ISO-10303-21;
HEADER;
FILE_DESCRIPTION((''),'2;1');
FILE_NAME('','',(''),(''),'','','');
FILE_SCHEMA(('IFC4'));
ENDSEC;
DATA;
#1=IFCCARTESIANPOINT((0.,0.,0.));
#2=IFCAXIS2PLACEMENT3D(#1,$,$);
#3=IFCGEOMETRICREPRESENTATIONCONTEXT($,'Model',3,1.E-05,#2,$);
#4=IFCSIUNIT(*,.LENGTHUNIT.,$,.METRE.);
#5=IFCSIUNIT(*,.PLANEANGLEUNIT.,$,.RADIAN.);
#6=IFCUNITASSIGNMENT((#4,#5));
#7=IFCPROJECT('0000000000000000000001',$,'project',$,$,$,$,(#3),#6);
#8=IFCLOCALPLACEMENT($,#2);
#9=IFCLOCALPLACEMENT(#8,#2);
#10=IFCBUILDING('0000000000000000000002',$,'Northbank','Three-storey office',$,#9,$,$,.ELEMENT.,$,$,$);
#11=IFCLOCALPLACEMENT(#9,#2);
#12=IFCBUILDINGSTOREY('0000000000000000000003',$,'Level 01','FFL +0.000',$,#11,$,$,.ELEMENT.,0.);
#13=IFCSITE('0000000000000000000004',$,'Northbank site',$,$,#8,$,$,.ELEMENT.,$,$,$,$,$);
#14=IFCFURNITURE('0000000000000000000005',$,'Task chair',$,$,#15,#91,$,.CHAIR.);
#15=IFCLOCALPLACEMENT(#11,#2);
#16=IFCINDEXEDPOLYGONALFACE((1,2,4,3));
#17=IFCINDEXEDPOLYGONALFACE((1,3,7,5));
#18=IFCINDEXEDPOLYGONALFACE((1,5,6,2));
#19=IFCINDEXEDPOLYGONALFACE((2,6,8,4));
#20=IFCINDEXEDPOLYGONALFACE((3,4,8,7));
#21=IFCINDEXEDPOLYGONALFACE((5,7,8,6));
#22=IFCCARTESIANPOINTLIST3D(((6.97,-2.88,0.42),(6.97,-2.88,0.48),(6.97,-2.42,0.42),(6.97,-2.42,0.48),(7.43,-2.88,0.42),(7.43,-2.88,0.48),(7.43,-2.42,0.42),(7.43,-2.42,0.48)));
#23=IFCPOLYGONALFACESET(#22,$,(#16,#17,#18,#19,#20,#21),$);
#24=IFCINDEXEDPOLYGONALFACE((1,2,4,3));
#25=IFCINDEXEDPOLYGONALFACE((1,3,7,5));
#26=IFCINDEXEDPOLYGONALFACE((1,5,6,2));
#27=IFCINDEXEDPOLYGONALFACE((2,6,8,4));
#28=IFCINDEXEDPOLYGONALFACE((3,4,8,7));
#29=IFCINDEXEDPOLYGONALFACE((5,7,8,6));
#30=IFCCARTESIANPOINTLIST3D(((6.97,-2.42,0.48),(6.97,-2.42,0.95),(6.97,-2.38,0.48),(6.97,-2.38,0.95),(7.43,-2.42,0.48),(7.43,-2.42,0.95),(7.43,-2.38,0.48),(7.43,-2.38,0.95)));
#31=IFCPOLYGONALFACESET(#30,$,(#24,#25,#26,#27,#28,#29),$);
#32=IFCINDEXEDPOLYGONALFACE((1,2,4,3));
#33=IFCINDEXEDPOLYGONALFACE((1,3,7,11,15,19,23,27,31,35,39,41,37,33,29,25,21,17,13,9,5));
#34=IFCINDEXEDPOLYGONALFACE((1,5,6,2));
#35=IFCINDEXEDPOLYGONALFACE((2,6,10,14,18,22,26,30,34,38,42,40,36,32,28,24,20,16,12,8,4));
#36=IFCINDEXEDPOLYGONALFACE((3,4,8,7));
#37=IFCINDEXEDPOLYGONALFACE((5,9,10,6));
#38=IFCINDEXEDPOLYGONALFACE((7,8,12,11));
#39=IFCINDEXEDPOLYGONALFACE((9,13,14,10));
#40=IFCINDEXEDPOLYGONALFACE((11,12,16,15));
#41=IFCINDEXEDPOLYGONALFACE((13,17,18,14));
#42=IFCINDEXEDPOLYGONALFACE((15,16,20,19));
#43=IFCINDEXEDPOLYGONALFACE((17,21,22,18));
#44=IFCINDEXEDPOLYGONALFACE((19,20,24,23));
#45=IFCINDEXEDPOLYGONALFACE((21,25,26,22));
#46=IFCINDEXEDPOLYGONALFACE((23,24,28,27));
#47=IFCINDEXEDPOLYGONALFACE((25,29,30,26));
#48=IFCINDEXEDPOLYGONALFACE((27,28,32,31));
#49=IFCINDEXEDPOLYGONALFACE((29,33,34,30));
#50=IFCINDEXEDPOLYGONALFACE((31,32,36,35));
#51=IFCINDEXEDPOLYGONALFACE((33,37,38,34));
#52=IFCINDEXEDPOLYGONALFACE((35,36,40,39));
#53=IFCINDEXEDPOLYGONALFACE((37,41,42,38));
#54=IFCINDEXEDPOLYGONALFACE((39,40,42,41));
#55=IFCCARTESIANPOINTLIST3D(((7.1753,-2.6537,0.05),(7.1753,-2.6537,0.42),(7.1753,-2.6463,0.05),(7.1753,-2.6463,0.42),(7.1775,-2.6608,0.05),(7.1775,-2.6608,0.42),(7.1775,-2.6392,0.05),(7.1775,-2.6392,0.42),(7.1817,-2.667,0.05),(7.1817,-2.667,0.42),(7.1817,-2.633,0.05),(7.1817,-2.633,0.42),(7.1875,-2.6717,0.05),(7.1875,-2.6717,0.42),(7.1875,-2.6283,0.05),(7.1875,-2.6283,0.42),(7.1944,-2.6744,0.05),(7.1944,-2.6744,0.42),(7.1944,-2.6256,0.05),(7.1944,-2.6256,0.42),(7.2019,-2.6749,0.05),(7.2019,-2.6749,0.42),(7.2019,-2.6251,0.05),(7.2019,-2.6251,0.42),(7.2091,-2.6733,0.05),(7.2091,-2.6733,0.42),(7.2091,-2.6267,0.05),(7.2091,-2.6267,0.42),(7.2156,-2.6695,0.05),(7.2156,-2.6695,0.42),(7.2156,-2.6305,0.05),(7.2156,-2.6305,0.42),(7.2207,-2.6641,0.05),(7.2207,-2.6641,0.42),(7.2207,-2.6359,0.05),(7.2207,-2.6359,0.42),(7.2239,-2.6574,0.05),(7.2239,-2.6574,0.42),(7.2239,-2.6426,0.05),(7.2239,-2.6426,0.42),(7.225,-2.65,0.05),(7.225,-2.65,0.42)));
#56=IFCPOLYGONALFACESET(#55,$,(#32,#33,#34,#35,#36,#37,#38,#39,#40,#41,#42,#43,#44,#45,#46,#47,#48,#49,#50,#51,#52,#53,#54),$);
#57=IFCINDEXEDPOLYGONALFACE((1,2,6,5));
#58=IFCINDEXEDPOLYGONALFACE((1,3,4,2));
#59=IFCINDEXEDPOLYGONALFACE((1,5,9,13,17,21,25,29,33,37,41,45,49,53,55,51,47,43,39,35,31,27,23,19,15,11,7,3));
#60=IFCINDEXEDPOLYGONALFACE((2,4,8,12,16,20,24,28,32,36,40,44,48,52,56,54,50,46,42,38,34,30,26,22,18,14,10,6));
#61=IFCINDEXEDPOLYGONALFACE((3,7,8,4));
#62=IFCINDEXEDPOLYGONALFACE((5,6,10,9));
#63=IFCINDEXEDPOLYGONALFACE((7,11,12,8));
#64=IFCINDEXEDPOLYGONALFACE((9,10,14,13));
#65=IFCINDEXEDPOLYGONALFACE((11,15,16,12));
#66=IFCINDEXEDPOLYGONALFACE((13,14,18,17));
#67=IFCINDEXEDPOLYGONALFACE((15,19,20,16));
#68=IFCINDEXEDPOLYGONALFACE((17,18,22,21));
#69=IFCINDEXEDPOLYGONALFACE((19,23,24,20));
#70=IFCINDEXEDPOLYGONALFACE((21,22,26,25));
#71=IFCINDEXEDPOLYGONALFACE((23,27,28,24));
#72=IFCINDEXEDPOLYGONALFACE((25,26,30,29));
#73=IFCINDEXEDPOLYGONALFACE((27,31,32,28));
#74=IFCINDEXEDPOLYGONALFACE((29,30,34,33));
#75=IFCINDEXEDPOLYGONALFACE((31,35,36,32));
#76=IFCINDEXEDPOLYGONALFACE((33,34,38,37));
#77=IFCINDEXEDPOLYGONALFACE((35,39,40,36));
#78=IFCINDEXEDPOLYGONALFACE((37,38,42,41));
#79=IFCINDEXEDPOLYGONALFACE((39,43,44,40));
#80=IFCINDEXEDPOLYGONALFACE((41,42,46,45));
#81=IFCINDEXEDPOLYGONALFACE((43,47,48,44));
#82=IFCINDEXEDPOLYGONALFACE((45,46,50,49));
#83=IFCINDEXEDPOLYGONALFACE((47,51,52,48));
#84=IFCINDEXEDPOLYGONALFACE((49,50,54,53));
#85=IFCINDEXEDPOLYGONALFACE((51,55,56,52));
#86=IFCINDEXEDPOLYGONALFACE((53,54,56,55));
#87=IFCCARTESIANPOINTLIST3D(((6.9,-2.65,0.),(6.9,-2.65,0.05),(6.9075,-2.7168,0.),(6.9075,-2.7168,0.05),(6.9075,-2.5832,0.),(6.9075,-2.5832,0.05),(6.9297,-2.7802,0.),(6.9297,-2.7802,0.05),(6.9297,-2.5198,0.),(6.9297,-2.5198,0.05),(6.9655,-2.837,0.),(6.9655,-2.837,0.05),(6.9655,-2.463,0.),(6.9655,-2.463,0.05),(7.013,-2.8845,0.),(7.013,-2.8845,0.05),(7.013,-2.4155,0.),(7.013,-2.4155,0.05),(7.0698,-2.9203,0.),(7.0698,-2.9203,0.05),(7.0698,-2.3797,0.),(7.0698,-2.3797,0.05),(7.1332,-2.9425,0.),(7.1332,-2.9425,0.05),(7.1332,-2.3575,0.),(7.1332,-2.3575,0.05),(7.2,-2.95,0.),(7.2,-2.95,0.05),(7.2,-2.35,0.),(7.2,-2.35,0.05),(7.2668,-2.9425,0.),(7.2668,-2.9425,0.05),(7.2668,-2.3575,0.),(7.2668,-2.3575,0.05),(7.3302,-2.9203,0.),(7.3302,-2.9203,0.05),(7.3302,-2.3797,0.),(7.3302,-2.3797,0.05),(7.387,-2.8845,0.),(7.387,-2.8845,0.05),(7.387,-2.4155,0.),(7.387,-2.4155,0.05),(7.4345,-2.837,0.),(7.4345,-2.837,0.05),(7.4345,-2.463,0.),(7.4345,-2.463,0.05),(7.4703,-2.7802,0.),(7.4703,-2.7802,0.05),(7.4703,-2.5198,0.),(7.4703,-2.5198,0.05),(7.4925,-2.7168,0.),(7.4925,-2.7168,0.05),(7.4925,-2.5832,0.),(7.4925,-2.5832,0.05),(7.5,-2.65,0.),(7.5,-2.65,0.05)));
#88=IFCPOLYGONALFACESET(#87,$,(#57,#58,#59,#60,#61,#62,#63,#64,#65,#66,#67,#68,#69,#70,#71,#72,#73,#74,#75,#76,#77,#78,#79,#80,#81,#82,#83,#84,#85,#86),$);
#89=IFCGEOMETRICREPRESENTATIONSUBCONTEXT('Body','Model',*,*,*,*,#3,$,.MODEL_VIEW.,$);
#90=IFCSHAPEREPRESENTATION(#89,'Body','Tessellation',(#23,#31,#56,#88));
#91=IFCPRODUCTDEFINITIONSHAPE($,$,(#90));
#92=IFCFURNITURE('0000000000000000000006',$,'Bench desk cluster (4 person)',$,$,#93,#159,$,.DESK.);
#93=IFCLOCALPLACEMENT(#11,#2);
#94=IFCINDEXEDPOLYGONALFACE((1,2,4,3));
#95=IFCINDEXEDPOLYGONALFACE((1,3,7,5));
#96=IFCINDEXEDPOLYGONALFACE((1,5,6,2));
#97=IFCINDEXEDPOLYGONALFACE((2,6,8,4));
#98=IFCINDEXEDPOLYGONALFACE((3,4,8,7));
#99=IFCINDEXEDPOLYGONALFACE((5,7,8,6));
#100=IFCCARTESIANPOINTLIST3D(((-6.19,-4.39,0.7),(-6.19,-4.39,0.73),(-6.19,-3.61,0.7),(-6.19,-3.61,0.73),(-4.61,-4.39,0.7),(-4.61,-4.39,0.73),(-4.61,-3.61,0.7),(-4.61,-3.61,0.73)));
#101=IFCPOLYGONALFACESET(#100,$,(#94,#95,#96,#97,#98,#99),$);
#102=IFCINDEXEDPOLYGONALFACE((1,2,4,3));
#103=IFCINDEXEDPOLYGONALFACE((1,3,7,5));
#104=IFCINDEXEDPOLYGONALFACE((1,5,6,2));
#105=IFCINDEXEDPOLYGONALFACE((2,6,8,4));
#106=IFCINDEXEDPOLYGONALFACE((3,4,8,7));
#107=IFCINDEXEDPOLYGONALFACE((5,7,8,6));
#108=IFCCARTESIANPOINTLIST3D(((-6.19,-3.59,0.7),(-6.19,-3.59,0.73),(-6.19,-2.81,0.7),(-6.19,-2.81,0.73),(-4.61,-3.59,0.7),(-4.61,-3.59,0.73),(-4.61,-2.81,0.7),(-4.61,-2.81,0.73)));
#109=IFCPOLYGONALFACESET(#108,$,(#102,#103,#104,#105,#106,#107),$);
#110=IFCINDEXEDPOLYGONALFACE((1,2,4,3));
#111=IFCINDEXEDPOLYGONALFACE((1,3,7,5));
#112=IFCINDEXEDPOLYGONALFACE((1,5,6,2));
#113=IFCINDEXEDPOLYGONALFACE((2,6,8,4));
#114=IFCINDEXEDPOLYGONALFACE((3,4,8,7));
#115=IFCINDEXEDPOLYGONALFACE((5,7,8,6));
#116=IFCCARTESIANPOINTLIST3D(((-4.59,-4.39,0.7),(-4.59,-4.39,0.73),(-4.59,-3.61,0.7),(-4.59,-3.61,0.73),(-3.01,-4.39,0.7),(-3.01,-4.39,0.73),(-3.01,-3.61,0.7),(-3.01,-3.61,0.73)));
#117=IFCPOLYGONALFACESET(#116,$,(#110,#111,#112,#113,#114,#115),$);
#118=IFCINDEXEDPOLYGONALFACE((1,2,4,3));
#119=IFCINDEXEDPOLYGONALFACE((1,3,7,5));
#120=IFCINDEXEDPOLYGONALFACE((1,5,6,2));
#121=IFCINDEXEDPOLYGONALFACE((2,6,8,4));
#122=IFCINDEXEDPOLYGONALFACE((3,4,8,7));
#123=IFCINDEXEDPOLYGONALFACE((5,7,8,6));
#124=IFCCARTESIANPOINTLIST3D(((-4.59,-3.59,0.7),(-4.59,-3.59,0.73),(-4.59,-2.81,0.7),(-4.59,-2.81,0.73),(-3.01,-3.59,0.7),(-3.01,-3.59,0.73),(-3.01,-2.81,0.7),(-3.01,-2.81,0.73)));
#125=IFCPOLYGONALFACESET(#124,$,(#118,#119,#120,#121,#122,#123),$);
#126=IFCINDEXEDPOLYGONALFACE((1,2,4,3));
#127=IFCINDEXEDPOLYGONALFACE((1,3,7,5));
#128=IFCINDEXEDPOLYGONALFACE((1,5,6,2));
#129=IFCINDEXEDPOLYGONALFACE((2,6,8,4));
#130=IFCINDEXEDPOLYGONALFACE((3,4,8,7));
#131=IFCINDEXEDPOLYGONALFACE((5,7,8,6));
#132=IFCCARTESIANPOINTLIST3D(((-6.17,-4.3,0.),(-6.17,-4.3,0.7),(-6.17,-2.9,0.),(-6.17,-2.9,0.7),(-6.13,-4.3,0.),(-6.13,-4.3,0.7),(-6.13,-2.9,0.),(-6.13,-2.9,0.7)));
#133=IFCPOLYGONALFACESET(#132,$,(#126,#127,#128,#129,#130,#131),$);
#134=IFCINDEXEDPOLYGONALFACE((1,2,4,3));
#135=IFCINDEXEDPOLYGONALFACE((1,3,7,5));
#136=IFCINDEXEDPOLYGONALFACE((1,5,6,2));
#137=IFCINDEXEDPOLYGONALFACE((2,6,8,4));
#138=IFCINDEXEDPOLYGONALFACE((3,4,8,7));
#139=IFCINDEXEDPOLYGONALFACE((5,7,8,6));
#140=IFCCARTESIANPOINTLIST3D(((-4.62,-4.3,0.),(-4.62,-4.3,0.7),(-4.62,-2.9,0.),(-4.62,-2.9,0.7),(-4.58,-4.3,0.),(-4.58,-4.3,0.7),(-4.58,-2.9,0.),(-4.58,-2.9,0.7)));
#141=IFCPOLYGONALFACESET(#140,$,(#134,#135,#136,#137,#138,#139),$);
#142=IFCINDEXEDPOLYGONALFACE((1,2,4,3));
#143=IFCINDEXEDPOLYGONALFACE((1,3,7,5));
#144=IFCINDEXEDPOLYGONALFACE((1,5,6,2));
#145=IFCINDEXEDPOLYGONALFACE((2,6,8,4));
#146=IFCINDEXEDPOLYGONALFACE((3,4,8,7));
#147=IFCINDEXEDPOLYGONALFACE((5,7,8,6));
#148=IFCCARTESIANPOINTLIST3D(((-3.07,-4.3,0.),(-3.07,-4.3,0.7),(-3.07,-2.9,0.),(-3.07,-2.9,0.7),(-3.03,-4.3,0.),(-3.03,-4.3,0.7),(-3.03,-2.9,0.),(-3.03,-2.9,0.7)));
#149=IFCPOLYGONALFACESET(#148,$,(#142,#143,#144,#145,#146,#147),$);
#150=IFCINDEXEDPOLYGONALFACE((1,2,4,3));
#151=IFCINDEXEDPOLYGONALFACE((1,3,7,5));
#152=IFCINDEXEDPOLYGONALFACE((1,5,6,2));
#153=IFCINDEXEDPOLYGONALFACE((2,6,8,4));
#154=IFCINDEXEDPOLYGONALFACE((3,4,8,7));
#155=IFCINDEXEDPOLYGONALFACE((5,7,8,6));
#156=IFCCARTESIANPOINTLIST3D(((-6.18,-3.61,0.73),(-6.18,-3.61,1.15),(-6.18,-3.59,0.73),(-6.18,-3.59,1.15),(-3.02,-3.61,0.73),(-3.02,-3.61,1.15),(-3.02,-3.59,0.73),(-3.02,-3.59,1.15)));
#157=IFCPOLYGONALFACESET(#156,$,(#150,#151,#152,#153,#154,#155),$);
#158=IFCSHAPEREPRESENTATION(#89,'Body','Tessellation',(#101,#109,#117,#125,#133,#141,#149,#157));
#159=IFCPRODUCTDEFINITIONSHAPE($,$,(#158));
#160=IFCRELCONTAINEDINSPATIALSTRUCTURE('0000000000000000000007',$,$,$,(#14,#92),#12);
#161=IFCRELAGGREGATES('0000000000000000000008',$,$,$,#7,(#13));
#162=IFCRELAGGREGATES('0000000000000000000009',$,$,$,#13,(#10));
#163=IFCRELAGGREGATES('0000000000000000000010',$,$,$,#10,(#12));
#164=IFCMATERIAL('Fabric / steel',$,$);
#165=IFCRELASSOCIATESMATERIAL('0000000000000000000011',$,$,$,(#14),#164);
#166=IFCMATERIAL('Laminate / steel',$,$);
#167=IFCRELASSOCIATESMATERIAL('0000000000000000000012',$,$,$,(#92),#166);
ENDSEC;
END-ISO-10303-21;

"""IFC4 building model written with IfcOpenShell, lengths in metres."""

from ifc_helpers import new_model, si_unit, frame, origin, place, context, subcontext, project, spatial, rectangle, circle, extrude, material, element, save


model = new_model("IFC4")

# Units and contexts
model_context = context("Model", 3, precision=1e-05, world=origin())
body_context = subcontext(model_context, "Body", "Model", "MODEL_VIEW")
ifc_project = project(units=[si_unit("LENGTHUNIT", "METRE"), si_unit("PLANEANGLEUNIT", "RADIAN")], contexts=[model_context])

# Site, building, storey
site_placement = place(None, origin())
site = spatial("IfcSite", under=ifc_project, at=site_placement, Name="Northbank site", CompositionType="ELEMENT")
building_placement = place(site_placement, origin())
building = spatial("IfcBuilding", under=site, at=building_placement, Name="Northbank", Description="Three-storey office", CompositionType="ELEMENT")
storey_placement = place(building_placement, origin())
storey = spatial("IfcBuildingStorey", under=building, at=storey_placement, Name="Level 01", Description="FFL +0.000", CompositionType="ELEMENT", Elevation=0.0)

# Furniture
ifc_material_1 = material(Name="Fabric / steel")
ifc_material_2 = material(Name="Laminate / steel")
furniture_1_placement = place(storey_placement, origin())
element("IfcFurniture", 1, at=furniture_1_placement, inside=storey, material=ifc_material_1, Name="Task chair", PredefinedType="CHAIR", context=body_context, shape_type="SweptSolid", body=[
    extrude(rectangle(XDim=0.46, YDim=0.46), frame((7.2, -2.65, 0.42)), (0.0, 0.0, 1.0), 0.06),
    extrude(rectangle(XDim=0.46, YDim=0.04), frame((7.2, -2.4, 0.48)), (0.0, 0.0, 1.0), 0.47),
    extrude(circle(Radius=0.025), frame((7.2, -2.65, 0.05), z_axis=(0.0, 0.0, 1.0), x_axis=(1.0, 0.0, 0.0)), (0.0, 0.0, 1.0), 0.37),
    extrude(circle(Radius=0.3), frame((7.2, -2.65, 0.0), z_axis=(0.0, 0.0, 1.0), x_axis=(1.0, 0.0, 0.0)), (0.0, 0.0, 1.0), 0.05),
])
furniture_2_placement = place(storey_placement, origin())
element("IfcFurniture", 2, at=furniture_2_placement, inside=storey, material=ifc_material_2, Name="Bench desk cluster (4 person)", PredefinedType="DESK", context=body_context, shape_type="SweptSolid", body=[
    extrude(rectangle(XDim=1.58, YDim=0.78), frame((-5.4, -4.0, 0.7)), (0.0, 0.0, 1.0), 0.03),
    extrude(rectangle(XDim=1.58, YDim=0.78), frame((-5.4, -3.2, 0.7)), (0.0, 0.0, 1.0), 0.03),
    extrude(rectangle(XDim=1.58, YDim=0.78), frame((-3.8, -4.0, 0.7)), (0.0, 0.0, 1.0), 0.03),
    extrude(rectangle(XDim=1.58, YDim=0.78), frame((-3.8, -3.2, 0.7)), (0.0, 0.0, 1.0), 0.03),
    extrude(rectangle(XDim=0.04, YDim=1.4), frame((-6.15, -3.6, 0.0)), (0.0, 0.0, 1.0), 0.7),
    extrude(rectangle(XDim=0.04, YDim=1.4), frame((-4.6, -3.6, 0.0)), (0.0, 0.0, 1.0), 0.7),
    extrude(rectangle(XDim=0.04, YDim=1.4), frame((-3.05, -3.6, 0.0)), (0.0, 0.0, 1.0), 0.7),
    extrude(rectangle(XDim=3.16, YDim=0.02), frame((-4.6, -3.6, 0.73)), (0.0, 0.0, 1.0), 0.42),
])

save(model, "model.ifc")
